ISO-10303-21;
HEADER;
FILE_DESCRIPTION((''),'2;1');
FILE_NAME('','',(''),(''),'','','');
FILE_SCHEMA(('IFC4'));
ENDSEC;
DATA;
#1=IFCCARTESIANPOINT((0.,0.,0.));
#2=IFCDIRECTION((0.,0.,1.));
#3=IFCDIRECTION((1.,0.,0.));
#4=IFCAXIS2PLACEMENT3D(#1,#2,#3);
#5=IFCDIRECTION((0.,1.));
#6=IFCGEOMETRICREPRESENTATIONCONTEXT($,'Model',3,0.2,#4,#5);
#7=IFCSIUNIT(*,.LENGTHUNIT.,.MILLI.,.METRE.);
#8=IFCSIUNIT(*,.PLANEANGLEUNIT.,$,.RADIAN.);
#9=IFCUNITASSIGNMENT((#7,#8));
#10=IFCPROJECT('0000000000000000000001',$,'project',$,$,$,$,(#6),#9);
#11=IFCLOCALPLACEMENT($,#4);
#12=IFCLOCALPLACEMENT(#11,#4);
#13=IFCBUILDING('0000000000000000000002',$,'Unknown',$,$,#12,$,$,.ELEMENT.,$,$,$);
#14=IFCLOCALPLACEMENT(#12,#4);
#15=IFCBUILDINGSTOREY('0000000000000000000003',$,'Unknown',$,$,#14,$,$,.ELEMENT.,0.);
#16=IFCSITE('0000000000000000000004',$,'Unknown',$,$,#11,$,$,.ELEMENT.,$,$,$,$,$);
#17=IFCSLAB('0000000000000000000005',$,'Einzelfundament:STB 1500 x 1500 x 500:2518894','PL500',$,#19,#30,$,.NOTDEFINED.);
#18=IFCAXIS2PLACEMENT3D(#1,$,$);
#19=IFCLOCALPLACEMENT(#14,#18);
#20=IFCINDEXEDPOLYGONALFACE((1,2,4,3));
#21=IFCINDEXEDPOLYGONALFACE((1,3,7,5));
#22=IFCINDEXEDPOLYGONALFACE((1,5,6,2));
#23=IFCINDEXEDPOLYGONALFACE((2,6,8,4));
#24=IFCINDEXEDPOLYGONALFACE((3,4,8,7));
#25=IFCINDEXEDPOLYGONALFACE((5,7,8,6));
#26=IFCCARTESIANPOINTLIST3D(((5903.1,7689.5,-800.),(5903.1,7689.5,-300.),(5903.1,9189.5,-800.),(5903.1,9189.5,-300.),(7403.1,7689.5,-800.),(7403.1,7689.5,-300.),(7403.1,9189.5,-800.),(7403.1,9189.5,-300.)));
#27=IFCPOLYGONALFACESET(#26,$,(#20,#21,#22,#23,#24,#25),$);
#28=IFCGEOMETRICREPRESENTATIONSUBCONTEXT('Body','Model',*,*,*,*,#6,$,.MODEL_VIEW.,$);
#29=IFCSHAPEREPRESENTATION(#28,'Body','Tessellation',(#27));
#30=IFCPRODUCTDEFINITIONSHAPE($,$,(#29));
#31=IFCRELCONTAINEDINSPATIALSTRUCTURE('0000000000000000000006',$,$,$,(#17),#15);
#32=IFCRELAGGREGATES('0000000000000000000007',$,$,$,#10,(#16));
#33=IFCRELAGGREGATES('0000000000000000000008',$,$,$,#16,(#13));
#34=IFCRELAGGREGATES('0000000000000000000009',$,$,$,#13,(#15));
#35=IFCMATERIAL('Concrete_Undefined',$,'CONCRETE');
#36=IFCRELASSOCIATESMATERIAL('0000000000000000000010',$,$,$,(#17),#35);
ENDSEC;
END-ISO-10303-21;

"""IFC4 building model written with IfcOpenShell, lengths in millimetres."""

from ifc_helpers import new_model, si_unit, direction, frame, origin_with_axes, place, context, subcontext, project, spatial, line, indexed_curve, outline, extrude, material, element, save


model = new_model("IFC4")

# Units and contexts
model_context = context("Model", 3, precision=0.2, world=origin_with_axes(), true_north=direction((0.0, 1.0)))
body_context = subcontext(model_context, "Body", "Model", "MODEL_VIEW")
ifc_project = project(units=[si_unit("LENGTHUNIT", "METRE", prefix="MILLI"), si_unit("PLANEANGLEUNIT", "RADIAN")], contexts=[model_context])

# Site, building, storey
site_placement = place(None, origin_with_axes())
site = spatial("IfcSite", under=ifc_project, at=site_placement, Name="Unknown", CompositionType="ELEMENT")
building_placement = place(site_placement, origin_with_axes())
building = spatial("IfcBuilding", under=site, at=building_placement, Name="Unknown", CompositionType="ELEMENT")
storey_placement = place(building_placement, origin_with_axes())
storey = spatial("IfcBuildingStorey", under=building, at=storey_placement, Name="Unknown", CompositionType="ELEMENT", Elevation=0.0)

# Shared definitions
ifc_material_1 = material(Name="Concrete_Undefined", Category="CONCRETE")

# Slab
for number, where, z_axis, x_axis, name in (
    (1, (5903.1, 9189.5, -550.0), (0.0, 0.0, -1.0), (1.0, 0.0, 0.0), "Einzelfundament:STB 1500 x 1500 x 500:2518894"),
):
    element("IfcSlab", number, at=place(storey_placement, frame(where, z_axis=z_axis, x_axis=x_axis)), inside=storey, material=ifc_material_1, Name=name, Description="PL500", PredefinedType="NOTDEFINED", context=body_context, shape_type="SolidModel", body=[
        extrude(outline(indexed_curve([(0.0, 0.0), (1500.0, 0.0), (1500.0, 1500.0), (0.0, 1500.0)], segments=[line(1, 2, 3, 4, 1)])), frame((0.0, 0.0, 250.0), z_axis=(0.0, 0.0, 1.0), x_axis=(1.0, 0.0, 0.0)), (0.0, 0.0, -1.0), 500.0),
    ])

save(model, "model.ifc")
